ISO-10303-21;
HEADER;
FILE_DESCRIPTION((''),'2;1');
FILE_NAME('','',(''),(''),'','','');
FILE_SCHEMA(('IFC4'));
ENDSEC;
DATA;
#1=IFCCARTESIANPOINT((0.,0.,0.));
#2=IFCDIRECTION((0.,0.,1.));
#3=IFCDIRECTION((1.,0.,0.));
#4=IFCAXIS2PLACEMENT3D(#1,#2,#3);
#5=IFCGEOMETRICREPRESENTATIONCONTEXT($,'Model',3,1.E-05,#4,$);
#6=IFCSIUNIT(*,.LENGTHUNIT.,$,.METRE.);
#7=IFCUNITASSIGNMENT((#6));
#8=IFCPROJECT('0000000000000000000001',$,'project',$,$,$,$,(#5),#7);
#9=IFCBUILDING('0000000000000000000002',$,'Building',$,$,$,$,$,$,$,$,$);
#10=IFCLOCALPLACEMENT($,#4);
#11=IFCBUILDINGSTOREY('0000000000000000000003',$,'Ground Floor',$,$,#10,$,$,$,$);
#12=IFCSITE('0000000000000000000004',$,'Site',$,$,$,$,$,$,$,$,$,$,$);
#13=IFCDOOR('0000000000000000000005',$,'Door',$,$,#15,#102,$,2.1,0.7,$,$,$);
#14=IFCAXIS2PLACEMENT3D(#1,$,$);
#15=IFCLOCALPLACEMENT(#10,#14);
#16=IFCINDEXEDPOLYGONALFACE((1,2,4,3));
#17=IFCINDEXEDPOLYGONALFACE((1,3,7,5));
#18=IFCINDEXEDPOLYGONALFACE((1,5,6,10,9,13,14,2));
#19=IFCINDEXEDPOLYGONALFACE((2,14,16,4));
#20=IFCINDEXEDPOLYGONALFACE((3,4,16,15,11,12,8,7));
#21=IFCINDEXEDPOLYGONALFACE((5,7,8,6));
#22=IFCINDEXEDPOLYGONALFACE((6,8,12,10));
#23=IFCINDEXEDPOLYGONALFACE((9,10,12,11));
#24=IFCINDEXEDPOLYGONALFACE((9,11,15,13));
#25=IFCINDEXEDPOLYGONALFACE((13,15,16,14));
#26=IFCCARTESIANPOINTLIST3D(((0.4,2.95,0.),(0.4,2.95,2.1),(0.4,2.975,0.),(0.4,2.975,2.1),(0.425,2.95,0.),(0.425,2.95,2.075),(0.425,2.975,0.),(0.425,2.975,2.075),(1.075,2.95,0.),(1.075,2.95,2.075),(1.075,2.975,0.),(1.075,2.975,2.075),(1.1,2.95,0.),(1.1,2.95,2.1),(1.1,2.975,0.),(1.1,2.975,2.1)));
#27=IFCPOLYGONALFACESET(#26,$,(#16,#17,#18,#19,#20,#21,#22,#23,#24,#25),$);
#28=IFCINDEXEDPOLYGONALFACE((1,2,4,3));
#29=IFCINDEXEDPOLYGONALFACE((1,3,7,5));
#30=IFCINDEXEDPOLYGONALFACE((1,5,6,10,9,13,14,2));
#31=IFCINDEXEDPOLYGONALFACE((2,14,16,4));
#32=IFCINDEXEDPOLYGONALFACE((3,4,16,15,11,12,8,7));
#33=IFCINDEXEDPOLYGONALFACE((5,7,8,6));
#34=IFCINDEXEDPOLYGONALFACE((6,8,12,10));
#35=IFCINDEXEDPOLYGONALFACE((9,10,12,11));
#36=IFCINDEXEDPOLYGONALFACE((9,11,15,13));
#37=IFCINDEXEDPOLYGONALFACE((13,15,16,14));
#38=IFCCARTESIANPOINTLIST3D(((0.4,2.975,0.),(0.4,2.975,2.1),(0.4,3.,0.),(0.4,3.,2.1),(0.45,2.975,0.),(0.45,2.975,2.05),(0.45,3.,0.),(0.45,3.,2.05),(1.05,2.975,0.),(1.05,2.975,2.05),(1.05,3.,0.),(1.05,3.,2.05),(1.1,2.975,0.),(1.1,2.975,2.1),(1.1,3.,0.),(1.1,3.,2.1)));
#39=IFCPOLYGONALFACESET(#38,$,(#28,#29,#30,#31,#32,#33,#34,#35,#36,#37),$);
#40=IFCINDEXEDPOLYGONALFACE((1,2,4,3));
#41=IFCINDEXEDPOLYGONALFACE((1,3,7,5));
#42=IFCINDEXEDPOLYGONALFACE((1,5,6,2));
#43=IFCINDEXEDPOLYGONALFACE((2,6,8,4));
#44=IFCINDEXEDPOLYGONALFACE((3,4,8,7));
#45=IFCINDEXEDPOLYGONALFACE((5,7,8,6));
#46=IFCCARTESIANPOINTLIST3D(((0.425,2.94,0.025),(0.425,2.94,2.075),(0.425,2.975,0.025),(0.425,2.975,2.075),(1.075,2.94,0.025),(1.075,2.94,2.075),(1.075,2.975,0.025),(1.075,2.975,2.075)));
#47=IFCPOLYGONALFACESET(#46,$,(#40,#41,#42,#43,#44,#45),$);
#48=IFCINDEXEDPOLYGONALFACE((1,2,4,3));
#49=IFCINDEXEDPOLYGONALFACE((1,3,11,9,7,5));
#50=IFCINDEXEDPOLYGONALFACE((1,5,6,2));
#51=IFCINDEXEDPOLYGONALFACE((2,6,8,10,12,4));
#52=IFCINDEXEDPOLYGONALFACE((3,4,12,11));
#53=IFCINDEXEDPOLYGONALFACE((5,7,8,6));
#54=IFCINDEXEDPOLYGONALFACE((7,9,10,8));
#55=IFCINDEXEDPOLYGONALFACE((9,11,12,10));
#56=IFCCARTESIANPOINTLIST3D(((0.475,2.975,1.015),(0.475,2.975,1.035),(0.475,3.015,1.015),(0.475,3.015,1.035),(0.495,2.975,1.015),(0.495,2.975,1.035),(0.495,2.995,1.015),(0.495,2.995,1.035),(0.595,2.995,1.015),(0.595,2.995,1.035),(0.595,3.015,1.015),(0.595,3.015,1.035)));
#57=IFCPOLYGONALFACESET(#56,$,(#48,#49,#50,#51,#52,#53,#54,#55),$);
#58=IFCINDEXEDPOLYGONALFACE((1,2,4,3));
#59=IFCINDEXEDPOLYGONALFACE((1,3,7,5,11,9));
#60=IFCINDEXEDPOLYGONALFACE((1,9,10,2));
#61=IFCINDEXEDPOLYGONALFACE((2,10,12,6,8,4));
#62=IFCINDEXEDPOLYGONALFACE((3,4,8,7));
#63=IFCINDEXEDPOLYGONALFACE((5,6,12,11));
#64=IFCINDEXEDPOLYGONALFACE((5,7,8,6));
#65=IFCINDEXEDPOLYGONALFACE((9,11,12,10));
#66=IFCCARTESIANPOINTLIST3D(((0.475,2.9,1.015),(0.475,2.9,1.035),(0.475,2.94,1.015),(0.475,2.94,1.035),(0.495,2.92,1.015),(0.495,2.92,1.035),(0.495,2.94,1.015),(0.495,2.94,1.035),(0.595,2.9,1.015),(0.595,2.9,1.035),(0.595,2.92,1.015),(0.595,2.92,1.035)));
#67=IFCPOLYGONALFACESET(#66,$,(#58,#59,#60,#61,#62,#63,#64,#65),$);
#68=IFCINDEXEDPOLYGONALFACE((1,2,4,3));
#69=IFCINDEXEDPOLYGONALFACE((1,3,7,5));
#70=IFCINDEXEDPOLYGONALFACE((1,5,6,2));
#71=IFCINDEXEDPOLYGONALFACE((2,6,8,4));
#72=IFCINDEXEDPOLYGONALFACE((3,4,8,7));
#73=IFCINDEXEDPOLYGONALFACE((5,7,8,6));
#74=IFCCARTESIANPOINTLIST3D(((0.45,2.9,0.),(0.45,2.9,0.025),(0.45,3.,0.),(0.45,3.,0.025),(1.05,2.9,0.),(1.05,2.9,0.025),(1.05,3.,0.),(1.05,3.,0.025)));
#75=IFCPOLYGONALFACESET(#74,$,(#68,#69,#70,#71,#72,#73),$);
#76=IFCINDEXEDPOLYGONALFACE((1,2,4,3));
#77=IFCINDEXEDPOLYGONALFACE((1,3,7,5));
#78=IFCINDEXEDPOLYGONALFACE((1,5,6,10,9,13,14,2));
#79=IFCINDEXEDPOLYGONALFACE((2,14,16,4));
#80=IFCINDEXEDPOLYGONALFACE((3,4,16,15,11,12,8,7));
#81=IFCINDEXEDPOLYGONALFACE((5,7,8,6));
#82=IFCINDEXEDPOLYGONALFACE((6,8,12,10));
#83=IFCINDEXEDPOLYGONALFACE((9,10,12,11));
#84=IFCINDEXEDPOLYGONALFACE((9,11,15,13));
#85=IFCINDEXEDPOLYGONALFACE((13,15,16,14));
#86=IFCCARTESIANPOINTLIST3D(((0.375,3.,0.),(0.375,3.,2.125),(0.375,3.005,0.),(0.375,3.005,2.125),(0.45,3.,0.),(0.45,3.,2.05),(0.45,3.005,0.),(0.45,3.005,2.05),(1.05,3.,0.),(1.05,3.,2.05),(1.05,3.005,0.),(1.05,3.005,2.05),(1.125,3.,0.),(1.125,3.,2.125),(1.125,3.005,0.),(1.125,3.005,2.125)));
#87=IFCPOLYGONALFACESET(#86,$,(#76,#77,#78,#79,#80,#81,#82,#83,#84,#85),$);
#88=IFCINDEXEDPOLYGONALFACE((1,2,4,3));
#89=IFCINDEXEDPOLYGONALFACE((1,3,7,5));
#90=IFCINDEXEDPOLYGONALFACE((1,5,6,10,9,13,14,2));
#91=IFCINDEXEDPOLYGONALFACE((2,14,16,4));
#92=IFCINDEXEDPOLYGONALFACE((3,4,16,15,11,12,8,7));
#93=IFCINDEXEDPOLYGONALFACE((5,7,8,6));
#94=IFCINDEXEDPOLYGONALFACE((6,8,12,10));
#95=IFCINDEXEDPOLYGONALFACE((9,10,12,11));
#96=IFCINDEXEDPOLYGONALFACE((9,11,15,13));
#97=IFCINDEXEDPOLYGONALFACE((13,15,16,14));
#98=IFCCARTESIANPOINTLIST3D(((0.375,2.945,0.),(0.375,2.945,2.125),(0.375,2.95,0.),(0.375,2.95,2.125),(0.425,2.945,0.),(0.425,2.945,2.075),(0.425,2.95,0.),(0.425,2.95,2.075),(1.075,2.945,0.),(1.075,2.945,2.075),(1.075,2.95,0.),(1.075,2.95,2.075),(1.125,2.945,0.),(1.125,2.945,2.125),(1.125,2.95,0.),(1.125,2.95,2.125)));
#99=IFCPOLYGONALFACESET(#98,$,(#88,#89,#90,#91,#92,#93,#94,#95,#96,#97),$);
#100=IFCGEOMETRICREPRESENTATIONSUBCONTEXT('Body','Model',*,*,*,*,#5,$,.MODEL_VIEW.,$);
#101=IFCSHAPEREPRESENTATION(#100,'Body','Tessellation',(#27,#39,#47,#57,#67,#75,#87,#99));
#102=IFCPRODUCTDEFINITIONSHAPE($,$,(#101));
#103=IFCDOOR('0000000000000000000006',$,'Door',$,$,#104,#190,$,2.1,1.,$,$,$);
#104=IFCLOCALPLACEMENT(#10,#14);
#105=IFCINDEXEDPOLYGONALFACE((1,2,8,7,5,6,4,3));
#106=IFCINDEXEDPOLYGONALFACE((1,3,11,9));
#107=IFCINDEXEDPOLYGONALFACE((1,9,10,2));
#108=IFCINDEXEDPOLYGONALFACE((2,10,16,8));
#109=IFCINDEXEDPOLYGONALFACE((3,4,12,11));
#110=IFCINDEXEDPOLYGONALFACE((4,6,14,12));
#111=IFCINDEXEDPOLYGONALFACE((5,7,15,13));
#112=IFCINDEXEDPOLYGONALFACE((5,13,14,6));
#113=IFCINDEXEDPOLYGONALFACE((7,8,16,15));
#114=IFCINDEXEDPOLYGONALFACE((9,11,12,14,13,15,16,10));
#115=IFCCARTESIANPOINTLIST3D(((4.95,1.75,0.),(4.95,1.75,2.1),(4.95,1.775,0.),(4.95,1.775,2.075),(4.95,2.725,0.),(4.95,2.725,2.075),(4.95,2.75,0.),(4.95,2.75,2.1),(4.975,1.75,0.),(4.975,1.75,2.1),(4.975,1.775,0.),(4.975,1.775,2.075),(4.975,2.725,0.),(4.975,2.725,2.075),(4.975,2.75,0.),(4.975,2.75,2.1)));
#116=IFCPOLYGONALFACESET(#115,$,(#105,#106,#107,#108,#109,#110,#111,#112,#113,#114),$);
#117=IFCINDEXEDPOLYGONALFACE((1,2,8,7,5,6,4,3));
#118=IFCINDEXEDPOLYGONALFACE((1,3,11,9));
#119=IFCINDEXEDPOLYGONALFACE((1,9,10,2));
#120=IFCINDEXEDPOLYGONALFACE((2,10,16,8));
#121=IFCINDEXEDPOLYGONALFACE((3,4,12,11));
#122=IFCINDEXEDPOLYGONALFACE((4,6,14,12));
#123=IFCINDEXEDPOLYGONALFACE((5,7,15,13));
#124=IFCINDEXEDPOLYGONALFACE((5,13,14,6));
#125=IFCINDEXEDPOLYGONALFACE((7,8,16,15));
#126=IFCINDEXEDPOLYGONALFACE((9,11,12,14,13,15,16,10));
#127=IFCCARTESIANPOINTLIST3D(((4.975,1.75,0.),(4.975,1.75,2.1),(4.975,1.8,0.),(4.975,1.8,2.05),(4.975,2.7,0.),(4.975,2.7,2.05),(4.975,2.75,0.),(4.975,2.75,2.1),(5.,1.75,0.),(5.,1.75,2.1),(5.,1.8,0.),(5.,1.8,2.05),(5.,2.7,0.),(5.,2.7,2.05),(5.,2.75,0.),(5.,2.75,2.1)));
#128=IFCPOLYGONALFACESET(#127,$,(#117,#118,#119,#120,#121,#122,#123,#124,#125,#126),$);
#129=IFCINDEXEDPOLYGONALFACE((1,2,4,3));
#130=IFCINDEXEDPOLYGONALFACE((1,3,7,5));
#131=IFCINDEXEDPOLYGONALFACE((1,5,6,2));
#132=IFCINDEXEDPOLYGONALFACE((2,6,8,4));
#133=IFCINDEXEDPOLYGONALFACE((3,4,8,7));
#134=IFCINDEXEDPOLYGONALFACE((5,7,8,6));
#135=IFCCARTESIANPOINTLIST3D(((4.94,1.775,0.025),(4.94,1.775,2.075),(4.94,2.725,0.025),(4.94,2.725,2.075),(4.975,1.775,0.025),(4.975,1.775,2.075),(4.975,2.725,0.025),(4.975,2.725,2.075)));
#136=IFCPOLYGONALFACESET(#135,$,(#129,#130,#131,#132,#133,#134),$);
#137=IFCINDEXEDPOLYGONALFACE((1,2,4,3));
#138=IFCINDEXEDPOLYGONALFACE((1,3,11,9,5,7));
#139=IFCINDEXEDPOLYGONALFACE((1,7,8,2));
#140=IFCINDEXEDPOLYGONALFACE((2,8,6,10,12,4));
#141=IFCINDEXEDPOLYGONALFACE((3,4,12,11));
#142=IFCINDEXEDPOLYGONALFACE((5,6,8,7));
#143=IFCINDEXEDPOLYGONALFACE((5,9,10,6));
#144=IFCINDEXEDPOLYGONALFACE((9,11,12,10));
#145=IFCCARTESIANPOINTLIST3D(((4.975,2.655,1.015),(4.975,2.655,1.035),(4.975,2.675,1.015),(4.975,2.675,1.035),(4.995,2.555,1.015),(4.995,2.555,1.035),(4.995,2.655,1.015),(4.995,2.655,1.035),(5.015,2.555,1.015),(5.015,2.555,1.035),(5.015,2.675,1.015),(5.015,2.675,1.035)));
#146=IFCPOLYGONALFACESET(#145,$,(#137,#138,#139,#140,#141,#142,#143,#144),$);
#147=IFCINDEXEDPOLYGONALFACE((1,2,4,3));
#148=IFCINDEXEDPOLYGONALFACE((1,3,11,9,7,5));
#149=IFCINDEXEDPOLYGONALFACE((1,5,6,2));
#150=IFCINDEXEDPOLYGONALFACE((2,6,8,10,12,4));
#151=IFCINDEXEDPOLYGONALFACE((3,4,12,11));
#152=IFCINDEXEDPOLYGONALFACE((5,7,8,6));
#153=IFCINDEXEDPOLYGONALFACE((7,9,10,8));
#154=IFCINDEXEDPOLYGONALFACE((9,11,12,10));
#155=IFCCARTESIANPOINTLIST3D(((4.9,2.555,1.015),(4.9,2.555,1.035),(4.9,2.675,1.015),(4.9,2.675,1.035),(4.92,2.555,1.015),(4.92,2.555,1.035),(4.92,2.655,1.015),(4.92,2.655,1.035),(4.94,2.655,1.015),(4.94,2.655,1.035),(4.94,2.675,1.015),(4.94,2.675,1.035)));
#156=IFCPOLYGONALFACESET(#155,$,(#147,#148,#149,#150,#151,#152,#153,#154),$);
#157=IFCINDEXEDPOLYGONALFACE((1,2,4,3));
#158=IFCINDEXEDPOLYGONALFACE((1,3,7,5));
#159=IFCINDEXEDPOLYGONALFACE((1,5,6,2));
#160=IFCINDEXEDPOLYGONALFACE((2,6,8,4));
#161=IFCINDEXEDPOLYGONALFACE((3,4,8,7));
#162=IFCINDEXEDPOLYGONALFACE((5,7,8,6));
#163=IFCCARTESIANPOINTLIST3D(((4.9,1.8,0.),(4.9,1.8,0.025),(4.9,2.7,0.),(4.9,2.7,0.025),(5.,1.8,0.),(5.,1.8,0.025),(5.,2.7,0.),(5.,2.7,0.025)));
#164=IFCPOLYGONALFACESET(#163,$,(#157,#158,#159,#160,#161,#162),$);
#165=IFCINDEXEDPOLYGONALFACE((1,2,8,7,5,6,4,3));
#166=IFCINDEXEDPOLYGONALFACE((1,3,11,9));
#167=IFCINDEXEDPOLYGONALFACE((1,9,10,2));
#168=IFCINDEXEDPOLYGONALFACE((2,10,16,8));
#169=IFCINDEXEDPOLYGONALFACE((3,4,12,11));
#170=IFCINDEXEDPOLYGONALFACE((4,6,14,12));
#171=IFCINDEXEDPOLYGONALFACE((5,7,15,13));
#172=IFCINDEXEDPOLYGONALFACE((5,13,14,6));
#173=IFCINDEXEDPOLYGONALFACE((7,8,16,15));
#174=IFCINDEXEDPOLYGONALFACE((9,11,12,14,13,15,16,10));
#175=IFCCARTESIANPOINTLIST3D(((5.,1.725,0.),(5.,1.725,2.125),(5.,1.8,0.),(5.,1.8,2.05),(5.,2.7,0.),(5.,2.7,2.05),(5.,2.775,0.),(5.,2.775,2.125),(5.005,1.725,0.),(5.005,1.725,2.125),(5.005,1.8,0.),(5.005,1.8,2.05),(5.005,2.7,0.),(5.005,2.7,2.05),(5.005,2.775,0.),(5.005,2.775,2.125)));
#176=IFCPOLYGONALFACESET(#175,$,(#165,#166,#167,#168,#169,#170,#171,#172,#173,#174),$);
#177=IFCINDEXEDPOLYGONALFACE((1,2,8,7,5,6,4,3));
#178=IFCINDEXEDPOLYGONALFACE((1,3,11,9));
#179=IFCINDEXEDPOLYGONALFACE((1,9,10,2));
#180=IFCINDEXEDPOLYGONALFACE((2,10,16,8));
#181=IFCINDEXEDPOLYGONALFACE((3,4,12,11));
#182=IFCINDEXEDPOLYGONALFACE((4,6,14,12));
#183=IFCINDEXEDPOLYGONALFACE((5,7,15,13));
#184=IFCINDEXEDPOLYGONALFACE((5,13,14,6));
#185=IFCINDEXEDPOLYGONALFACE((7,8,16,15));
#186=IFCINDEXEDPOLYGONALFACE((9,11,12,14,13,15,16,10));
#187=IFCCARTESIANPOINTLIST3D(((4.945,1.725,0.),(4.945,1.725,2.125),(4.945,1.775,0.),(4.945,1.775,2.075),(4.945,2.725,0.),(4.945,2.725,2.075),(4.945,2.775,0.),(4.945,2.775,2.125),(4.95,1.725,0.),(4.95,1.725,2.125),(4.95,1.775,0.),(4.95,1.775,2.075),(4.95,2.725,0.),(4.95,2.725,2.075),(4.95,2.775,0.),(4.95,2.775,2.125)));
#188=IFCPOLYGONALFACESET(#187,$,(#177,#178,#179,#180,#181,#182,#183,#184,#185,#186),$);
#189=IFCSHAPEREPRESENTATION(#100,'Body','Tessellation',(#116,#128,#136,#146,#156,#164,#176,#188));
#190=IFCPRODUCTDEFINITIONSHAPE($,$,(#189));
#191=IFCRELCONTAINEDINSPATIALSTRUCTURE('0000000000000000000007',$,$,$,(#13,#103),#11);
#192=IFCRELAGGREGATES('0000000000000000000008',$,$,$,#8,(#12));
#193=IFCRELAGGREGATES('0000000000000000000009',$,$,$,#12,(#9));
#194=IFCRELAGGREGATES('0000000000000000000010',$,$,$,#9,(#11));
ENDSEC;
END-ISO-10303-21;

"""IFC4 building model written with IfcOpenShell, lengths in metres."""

from ifc_helpers import new_model, si_unit, frame, origin_with_axes, place, context, subcontext, project, spatial, line, indexed_curve, outline, extrude, element, save


model = new_model("IFC4")

# Units and contexts
model_context = context("Model", 3, precision=1e-05, world=origin_with_axes())
body_context = subcontext(model_context, "Body", "Model", "MODEL_VIEW")
ifc_project = project(units=[si_unit("LENGTHUNIT", "METRE")], contexts=[model_context])

# Site, building, storey
site = spatial("IfcSite", under=ifc_project, Name="Site")
building = spatial("IfcBuilding", under=site, Name="Building")
storey_placement = place(None, origin_with_axes())
storey = spatial("IfcBuildingStorey", under=building, at=storey_placement, Name="Ground Floor")

# Doors
door_1_placement = place(storey_placement, frame((1.1, 3.0, 0.0), z_axis=(0.0, 0.0, 1.0), x_axis=(-1.0, 0.0, 0.0)))
element("IfcDoor", 1, at=door_1_placement, inside=storey, Name="Door", OverallHeight=2.1, OverallWidth=0.7, context=body_context, shape_type="SweptSolid", body=[
    extrude(outline(indexed_curve([(0.0, 0.0), (0.0, 2.1), (0.7, 2.1), (0.7, 0.0), (0.675, 0.0), (0.675, 2.075), (0.025, 2.075), (0.025, 0.0)], segments=[line(1, 2, 3, 4, 5, 6, 7, 8, 1)])), frame((0.0, 0.025, 0.0), z_axis=(0.0, -1.0, 0.0), x_axis=(1.0, 0.0, 0.0)), (0.0, 0.0, -1.0), 0.025),
    extrude(outline(indexed_curve([(0.0, 0.0), (0.0, 2.1), (0.7, 2.1), (0.7, 0.0), (0.65, 0.0), (0.65, 2.05), (0.05, 2.05), (0.05, 0.0)], segments=[line(1, 2, 3, 4, 5, 6, 7, 8, 1)])), frame((0.0, 0.0, 0.0), z_axis=(0.0, -1.0, 0.0), x_axis=(1.0, 0.0, 0.0)), (0.0, 0.0, -1.0), 0.025),
    extrude(outline(indexed_curve([(0.0, 0.0), (0.65, 0.0), (0.65, 0.035), (0.0, 0.035)], segments=[line(1, 2, 3, 4, 1)])), frame((0.025, 0.025, 0.025), z_axis=(0.0, 0.0, 1.0), x_axis=(1.0, 0.0, 0.0)), (0.0, 0.0, 1.0), 2.05),
    extrude(outline(indexed_curve([(0.0, 0.0), (0.0, -0.04), (-0.12, -0.04), (-0.12, -0.02), (-0.02, -0.02), (-0.02, 0.0)], segments=[line(1, 2, 3, 4, 5, 6, 1)])), frame((0.625, 0.025, 1.015), z_axis=(0.0, 0.0, 1.0), x_axis=(1.0, 0.0, 0.0)), (0.0, 0.0, 1.0), 0.02),
    extrude(outline(indexed_curve([(0.0, 0.0), (0.0, 0.04), (-0.12, 0.04), (-0.12, 0.02), (-0.02, 0.02), (-0.02, 0.0)], segments=[line(1, 2, 3, 4, 5, 6, 1)])), frame((0.625, 0.06, 1.015), z_axis=(0.0, 0.0, 1.0), x_axis=(1.0, 0.0, 0.0)), (0.0, 0.0, 1.0), 0.02),
    extrude(outline(indexed_curve([(0.0, 0.0), (0.6, 0.0), (0.6, 0.1), (0.0, 0.1)], segments=[line(1, 2, 3, 4, 1)])), frame((0.05, 0.0, 0.0), z_axis=(0.0, 0.0, 1.0), x_axis=(1.0, 0.0, 0.0)), (0.0, 0.0, 1.0), 0.025),
    extrude(outline(indexed_curve([(0.0, 0.0), (0.0, 2.125), (0.75, 2.125), (0.75, 0.0), (0.675, 0.0), (0.675, 2.05), (0.075, 2.05), (0.075, 0.0)], segments=[line(1, 2, 3, 4, 5, 6, 7, 8, 1)])), frame((-0.025, -0.005, 0.0), z_axis=(0.0, -1.0, 0.0), x_axis=(1.0, 0.0, 0.0)), (0.0, 0.0, -1.0), 0.005),
    extrude(outline(indexed_curve([(0.0, 0.0), (0.0, 2.125), (0.75, 2.125), (0.75, 0.0), (0.7, 0.0), (0.7, 2.075), (0.05, 2.075), (0.05, 0.0)], segments=[line(1, 2, 3, 4, 5, 6, 7, 8, 1)])), frame((-0.025, 0.05, 0.0), z_axis=(0.0, -1.0, 0.0), x_axis=(1.0, 0.0, 0.0)), (0.0, 0.0, -1.0), 0.005),
])
door_2_placement = place(storey_placement, frame((5.0, 1.75, 0.0), z_axis=(0.0, 0.0, 1.0), x_axis=(0.0, 1.0, 0.0)))
element("IfcDoor", 2, at=door_2_placement, inside=storey, Name="Door", OverallHeight=2.1, OverallWidth=1.0, context=body_context, shape_type="SweptSolid", body=[
    extrude(outline(indexed_curve([(0.0, 0.0), (0.0, 2.1), (1.0, 2.1), (1.0, 0.0), (0.975, 0.0), (0.975, 2.075), (0.025, 2.075), (0.025, 0.0)], segments=[line(1, 2, 3, 4, 5, 6, 7, 8, 1)])), frame((0.0, 0.025, 0.0), z_axis=(0.0, -1.0, 0.0), x_axis=(1.0, 0.0, 0.0)), (0.0, 0.0, -1.0), 0.025),
    extrude(outline(indexed_curve([(0.0, 0.0), (0.0, 2.1), (1.0, 2.1), (1.0, 0.0), (0.95, 0.0), (0.95, 2.05), (0.05, 2.05), (0.05, 0.0)], segments=[line(1, 2, 3, 4, 5, 6, 7, 8, 1)])), frame((0.0, 0.0, 0.0), z_axis=(0.0, -1.0, 0.0), x_axis=(1.0, 0.0, 0.0)), (0.0, 0.0, -1.0), 0.025),
    extrude(outline(indexed_curve([(0.0, 0.0), (0.95, 0.0), (0.95, 0.035), (0.0, 0.035)], segments=[line(1, 2, 3, 4, 1)])), frame((0.025, 0.025, 0.025), z_axis=(0.0, 0.0, 1.0), x_axis=(1.0, 0.0, 0.0)), (0.0, 0.0, 1.0), 2.05),
    extrude(outline(indexed_curve([(0.0, 0.0), (0.0, -0.04), (-0.12, -0.04), (-0.12, -0.02), (-0.02, -0.02), (-0.02, 0.0)], segments=[line(1, 2, 3, 4, 5, 6, 1)])), frame((0.925, 0.025, 1.015), z_axis=(0.0, 0.0, 1.0), x_axis=(1.0, 0.0, 0.0)), (0.0, 0.0, 1.0), 0.02),
    extrude(outline(indexed_curve([(0.0, 0.0), (0.0, 0.04), (-0.12, 0.04), (-0.12, 0.02), (-0.02, 0.02), (-0.02, 0.0)], segments=[line(1, 2, 3, 4, 5, 6, 1)])), frame((0.925, 0.06, 1.015), z_axis=(0.0, 0.0, 1.0), x_axis=(1.0, 0.0, 0.0)), (0.0, 0.0, 1.0), 0.02),
    extrude(outline(indexed_curve([(0.0, 0.0), (0.9, 0.0), (0.9, 0.1), (0.0, 0.1)], segments=[line(1, 2, 3, 4, 1)])), frame((0.05, 0.0, 0.0), z_axis=(0.0, 0.0, 1.0), x_axis=(1.0, 0.0, 0.0)), (0.0, 0.0, 1.0), 0.025),
    extrude(outline(indexed_curve([(0.0, 0.0), (0.0, 2.125), (1.05, 2.125), (1.05, 0.0), (0.975, 0.0), (0.975, 2.05), (0.075, 2.05), (0.075, 0.0)], segments=[line(1, 2, 3, 4, 5, 6, 7, 8, 1)])), frame((-0.025, -0.005, 0.0), z_axis=(0.0, -1.0, 0.0), x_axis=(1.0, 0.0, 0.0)), (0.0, 0.0, -1.0), 0.005),
    extrude(outline(indexed_curve([(0.0, 0.0), (0.0, 2.125), (1.05, 2.125), (1.05, 0.0), (1.0, 0.0), (1.0, 2.075), (0.05, 2.075), (0.05, 0.0)], segments=[line(1, 2, 3, 4, 5, 6, 7, 8, 1)])), frame((-0.025, 0.05, 0.0), z_axis=(0.0, -1.0, 0.0), x_axis=(1.0, 0.0, 0.0)), (0.0, 0.0, -1.0), 0.005),
])

save(model, "model.ifc")
